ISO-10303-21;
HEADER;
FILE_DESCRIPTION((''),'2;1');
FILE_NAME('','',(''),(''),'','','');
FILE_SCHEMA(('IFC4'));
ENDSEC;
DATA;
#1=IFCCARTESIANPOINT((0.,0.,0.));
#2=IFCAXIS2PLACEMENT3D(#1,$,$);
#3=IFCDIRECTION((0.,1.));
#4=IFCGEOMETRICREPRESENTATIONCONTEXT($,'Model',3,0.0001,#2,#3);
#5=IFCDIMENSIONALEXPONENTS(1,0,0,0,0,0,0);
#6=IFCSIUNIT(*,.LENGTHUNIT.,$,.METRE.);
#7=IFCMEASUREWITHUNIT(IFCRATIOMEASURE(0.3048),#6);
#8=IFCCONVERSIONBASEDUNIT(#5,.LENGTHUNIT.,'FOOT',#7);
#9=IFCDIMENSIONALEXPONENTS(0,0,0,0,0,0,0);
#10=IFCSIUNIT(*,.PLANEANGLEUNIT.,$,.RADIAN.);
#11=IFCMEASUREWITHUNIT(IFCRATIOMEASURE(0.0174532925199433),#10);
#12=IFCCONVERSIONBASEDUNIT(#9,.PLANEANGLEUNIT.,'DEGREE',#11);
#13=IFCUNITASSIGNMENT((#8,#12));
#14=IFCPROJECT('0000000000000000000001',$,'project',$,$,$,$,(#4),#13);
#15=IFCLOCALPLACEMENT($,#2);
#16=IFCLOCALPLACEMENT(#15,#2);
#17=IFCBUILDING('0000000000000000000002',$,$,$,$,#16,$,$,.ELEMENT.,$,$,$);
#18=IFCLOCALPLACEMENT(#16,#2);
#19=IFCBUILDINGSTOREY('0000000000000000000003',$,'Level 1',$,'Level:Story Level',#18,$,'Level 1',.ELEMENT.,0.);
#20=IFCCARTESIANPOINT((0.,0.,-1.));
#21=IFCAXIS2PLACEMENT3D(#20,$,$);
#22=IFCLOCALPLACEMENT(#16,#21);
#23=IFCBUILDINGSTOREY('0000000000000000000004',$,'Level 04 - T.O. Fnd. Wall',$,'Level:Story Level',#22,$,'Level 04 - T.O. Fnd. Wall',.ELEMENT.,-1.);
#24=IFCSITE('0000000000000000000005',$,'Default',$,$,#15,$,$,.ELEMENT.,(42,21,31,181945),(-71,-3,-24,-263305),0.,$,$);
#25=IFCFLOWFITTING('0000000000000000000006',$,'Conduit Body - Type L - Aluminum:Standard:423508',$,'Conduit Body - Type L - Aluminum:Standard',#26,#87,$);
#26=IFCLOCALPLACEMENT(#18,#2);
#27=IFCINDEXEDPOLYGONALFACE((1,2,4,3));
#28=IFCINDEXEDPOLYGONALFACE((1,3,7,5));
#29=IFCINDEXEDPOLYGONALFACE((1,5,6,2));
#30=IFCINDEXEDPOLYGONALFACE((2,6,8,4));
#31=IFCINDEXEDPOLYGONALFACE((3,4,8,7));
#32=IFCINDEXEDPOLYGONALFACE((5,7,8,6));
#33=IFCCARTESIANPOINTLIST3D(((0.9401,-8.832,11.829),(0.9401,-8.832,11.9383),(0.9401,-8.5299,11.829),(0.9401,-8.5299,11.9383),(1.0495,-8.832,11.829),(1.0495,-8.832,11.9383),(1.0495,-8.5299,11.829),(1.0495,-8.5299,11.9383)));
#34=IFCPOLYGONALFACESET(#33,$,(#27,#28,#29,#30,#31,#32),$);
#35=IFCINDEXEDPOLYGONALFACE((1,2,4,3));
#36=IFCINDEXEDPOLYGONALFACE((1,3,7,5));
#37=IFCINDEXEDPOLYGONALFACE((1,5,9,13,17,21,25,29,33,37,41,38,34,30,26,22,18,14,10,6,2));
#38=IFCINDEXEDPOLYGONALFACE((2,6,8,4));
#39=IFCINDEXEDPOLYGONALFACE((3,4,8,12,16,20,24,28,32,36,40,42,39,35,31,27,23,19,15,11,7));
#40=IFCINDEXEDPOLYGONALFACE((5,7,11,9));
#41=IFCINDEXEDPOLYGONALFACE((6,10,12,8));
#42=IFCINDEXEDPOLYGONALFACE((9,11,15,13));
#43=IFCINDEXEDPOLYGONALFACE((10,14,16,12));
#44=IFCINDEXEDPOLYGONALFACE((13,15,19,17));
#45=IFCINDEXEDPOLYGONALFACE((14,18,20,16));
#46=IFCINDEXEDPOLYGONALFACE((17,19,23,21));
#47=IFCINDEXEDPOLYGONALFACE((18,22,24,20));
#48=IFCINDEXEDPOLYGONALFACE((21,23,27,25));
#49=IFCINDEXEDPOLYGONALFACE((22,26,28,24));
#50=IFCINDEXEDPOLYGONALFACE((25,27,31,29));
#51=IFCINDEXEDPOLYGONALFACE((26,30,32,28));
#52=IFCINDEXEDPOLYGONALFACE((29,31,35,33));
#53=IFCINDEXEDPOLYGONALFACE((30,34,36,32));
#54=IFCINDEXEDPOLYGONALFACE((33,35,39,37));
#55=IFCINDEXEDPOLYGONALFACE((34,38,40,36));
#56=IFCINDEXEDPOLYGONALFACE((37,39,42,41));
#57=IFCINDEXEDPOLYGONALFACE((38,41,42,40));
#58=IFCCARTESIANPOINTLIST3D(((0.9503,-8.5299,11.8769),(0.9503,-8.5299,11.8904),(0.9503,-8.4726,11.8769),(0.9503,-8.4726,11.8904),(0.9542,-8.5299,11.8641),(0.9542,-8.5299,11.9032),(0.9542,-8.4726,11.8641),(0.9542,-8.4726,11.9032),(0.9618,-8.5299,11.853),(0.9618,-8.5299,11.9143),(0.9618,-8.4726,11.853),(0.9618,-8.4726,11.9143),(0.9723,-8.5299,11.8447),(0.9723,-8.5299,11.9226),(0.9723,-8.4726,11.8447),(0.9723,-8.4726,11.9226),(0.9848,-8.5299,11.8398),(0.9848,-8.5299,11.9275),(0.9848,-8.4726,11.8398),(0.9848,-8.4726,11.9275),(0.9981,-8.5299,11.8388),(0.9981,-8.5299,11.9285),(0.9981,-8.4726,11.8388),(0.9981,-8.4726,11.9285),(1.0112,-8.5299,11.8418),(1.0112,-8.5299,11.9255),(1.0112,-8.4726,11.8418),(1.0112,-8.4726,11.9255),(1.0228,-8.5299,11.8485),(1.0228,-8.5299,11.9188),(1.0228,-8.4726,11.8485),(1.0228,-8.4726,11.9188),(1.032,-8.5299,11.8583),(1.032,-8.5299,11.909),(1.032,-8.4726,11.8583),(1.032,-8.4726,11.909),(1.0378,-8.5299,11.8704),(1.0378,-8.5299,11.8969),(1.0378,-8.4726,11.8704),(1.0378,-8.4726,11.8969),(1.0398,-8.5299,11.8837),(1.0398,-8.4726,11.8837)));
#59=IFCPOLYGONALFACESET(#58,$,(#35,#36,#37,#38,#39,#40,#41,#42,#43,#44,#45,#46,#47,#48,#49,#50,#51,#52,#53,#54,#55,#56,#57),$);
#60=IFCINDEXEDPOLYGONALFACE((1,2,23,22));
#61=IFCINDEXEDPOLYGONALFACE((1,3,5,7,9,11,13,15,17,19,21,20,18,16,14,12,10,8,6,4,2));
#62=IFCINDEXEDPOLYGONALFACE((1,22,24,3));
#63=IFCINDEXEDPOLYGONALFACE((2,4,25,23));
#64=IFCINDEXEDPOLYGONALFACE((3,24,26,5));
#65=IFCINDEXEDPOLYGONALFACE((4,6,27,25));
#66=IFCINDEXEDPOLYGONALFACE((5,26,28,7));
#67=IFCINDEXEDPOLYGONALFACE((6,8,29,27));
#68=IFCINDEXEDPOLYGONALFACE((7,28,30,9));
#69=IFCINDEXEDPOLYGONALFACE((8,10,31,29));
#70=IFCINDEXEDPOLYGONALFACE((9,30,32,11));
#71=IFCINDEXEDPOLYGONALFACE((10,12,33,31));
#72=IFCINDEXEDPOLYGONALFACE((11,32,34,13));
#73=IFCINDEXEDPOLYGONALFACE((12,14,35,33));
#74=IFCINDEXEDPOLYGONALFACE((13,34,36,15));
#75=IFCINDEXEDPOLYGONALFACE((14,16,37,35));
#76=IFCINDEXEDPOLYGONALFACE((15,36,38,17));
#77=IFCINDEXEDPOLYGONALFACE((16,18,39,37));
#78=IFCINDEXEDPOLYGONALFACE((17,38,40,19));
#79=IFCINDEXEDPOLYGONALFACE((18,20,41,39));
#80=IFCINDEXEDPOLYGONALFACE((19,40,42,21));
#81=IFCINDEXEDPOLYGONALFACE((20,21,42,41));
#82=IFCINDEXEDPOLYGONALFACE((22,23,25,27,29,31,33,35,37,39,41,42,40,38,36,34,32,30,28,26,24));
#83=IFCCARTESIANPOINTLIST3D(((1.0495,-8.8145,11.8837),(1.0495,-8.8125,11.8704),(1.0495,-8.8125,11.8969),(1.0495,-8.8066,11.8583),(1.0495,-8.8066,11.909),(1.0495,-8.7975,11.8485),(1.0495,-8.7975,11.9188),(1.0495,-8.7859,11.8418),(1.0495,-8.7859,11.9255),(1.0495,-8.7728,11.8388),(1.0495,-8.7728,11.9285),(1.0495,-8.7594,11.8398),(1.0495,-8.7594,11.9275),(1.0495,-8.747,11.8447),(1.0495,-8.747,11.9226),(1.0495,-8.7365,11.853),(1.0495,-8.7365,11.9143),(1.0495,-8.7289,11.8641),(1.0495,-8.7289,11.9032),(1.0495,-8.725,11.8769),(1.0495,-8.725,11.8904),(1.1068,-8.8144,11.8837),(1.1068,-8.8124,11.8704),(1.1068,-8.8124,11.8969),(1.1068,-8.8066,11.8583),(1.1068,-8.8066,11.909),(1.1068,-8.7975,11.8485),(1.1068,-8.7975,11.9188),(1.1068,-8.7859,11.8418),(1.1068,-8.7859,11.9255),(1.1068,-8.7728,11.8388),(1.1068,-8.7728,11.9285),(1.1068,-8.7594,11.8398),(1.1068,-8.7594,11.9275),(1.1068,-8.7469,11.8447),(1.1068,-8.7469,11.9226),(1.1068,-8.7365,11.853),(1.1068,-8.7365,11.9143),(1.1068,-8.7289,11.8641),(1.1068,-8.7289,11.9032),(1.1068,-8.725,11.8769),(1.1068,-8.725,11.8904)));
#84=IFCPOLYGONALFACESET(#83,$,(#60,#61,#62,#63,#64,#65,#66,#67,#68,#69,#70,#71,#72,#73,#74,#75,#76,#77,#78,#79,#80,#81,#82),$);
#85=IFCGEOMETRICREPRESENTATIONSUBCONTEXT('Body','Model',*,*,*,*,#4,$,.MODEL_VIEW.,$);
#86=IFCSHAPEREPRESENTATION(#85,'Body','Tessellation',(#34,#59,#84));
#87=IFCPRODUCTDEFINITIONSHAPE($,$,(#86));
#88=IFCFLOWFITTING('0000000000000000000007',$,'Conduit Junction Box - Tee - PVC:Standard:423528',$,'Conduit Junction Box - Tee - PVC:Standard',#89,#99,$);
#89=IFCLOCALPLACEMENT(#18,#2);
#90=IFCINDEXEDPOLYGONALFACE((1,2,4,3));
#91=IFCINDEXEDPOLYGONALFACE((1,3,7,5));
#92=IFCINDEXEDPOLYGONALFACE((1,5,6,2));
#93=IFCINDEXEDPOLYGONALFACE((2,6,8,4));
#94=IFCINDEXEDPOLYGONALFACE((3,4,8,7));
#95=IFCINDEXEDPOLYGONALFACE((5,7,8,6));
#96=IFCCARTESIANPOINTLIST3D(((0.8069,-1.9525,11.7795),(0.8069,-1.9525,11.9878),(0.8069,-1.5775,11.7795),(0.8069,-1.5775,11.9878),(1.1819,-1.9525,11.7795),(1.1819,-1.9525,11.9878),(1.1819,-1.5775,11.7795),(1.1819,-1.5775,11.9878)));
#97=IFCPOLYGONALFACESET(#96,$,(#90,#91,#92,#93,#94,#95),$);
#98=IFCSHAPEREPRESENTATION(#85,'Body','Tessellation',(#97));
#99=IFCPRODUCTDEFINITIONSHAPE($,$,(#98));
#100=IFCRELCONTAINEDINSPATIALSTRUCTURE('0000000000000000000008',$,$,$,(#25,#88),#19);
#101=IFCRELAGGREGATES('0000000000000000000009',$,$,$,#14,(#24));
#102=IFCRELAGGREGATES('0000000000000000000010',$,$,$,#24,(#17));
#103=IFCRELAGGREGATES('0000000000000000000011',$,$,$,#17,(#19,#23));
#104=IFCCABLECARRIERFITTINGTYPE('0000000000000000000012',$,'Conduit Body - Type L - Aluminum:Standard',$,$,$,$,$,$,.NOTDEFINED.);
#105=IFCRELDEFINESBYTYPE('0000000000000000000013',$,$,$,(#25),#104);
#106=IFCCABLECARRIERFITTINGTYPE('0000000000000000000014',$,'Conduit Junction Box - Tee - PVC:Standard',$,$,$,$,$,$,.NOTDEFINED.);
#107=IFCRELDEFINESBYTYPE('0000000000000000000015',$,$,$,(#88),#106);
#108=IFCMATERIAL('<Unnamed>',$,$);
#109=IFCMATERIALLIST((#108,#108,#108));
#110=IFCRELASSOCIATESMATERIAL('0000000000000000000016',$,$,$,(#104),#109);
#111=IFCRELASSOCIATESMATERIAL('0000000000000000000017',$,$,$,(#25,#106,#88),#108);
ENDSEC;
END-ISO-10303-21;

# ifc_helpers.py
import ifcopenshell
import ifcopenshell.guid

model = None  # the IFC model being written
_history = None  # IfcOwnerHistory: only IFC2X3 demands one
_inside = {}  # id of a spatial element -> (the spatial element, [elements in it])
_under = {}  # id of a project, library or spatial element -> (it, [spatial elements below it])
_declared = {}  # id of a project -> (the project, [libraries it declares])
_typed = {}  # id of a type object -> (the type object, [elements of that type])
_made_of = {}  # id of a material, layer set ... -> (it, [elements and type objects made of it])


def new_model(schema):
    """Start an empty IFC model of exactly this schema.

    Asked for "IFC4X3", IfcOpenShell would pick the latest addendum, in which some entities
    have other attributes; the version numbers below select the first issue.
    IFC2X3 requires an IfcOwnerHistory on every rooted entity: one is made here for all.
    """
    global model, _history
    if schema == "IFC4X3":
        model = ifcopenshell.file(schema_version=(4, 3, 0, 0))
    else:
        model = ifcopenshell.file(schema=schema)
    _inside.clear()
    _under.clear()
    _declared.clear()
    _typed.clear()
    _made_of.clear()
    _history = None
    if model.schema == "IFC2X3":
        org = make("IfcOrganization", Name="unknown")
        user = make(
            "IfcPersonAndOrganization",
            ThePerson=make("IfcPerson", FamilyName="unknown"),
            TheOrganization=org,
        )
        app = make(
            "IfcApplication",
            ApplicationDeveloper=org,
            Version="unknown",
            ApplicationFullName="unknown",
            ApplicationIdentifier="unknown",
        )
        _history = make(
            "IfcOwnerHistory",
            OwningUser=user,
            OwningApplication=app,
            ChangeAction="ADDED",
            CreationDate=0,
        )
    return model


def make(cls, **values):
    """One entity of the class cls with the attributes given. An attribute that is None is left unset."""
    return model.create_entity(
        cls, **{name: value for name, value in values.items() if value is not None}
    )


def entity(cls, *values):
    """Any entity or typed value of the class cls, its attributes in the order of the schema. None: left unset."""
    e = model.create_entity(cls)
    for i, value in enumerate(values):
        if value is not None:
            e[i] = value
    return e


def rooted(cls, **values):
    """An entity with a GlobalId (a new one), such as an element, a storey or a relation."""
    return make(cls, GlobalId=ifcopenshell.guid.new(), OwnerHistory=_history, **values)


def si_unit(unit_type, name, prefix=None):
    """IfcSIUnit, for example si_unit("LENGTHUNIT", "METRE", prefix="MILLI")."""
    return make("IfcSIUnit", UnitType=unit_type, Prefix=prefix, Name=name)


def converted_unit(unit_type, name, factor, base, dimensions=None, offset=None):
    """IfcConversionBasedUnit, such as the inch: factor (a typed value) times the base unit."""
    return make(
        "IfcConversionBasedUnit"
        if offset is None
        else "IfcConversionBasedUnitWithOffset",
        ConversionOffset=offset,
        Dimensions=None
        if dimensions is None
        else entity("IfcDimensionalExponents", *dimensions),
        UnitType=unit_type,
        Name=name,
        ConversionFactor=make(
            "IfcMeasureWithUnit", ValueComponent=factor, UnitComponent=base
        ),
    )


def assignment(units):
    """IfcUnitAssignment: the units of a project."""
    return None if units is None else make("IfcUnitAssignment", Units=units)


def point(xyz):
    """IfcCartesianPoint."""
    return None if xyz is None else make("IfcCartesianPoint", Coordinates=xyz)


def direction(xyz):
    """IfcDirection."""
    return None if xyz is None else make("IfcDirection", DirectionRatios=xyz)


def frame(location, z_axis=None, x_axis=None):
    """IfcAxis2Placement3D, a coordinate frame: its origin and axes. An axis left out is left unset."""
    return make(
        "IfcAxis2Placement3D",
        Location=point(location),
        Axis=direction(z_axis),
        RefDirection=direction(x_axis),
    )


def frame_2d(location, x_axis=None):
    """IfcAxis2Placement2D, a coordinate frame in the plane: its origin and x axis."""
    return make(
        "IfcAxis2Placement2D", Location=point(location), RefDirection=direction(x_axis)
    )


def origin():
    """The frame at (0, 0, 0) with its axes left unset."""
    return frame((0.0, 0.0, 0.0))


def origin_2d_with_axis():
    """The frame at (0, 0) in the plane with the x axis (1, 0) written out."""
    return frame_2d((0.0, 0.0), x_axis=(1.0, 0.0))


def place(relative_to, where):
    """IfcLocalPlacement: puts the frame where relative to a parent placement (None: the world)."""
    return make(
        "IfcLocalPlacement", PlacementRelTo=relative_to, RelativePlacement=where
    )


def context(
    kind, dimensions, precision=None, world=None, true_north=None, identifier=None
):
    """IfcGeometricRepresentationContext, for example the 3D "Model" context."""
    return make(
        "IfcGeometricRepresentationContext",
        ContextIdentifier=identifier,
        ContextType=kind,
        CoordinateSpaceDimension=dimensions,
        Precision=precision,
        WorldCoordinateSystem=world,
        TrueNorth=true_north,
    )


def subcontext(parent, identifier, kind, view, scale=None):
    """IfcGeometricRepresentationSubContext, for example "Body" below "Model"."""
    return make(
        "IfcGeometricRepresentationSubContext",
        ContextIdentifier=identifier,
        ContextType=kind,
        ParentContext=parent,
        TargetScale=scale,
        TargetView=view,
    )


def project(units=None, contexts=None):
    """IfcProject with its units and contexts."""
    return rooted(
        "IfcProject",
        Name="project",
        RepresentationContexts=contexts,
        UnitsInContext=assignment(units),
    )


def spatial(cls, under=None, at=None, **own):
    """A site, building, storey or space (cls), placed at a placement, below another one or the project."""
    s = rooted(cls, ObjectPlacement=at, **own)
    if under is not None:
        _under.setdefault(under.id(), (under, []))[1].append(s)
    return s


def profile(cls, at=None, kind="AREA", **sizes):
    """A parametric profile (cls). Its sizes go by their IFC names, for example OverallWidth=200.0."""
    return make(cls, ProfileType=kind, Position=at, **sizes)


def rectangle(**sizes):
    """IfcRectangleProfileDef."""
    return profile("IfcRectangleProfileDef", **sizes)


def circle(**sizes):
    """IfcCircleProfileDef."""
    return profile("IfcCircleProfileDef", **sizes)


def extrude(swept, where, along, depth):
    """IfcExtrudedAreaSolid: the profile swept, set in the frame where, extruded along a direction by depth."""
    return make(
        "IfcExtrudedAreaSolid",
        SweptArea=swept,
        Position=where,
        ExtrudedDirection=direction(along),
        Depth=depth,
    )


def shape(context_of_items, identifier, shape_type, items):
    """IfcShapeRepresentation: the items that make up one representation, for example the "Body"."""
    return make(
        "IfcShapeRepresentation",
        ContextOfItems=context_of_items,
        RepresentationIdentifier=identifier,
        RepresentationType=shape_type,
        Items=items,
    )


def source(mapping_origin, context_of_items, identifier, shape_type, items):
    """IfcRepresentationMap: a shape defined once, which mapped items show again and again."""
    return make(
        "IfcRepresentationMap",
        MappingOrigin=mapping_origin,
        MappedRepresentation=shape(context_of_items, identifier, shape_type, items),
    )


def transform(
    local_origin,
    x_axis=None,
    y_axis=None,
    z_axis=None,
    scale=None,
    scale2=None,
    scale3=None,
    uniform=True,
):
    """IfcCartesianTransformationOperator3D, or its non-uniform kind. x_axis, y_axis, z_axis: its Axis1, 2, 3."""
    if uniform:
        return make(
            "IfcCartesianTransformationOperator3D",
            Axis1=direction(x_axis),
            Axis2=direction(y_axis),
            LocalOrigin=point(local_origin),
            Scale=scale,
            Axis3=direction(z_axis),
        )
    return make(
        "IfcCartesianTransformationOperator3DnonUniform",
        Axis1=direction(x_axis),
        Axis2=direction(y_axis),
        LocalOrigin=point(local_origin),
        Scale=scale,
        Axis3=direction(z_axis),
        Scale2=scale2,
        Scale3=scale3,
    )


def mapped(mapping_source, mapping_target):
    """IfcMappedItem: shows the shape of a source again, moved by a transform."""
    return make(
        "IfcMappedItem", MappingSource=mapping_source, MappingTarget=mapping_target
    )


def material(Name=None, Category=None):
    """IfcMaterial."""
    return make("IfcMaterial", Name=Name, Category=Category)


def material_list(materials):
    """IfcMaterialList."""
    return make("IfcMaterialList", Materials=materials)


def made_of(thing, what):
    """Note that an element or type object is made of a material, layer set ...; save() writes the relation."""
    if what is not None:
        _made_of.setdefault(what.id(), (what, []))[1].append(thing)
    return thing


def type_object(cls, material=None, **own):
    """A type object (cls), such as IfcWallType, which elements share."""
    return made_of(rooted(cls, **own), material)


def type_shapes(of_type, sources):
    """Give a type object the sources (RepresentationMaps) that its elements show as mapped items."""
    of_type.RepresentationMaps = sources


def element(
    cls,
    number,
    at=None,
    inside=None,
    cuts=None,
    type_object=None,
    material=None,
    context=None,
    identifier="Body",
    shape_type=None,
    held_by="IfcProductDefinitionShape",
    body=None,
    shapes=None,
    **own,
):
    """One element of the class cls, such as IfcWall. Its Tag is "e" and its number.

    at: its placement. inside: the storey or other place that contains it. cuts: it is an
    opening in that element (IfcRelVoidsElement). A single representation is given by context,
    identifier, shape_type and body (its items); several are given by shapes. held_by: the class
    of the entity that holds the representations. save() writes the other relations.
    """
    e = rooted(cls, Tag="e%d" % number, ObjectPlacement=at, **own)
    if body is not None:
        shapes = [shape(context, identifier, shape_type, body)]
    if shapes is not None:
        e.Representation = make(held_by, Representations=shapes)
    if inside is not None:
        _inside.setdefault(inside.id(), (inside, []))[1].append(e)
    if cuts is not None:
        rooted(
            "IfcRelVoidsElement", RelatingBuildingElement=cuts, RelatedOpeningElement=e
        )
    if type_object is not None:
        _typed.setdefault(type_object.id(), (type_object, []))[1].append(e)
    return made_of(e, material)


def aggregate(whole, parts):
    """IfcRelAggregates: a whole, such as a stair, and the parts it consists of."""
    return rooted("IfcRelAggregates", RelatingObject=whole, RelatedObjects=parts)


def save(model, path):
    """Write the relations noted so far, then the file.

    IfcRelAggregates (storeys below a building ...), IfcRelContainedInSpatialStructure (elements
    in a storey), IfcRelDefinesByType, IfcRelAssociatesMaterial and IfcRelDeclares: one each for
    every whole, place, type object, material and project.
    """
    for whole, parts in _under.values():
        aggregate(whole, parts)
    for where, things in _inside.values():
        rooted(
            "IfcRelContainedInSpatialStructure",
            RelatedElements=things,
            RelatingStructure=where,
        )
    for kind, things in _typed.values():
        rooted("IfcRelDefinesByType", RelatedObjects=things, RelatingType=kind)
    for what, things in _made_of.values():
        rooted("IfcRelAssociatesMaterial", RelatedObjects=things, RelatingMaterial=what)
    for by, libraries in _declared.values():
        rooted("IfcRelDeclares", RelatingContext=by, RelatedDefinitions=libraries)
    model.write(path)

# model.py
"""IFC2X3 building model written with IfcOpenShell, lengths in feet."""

from ifc_helpers import new_model, entity, si_unit, converted_unit, direction, frame, frame_2d, origin, origin_2d_with_axis, place, context, subcontext, project, spatial, rectangle, circle, extrude, source, transform, mapped, material, material_list, type_object, type_shapes, element, save


model = new_model("IFC2X3")

# Units and contexts
model_context = context("Model", 3, precision=0.0001, world=origin(), true_north=direction((0.0, 1.0)))
body_context = subcontext(model_context, "Body", "Model", "MODEL_VIEW")
ifc_project = project(units=[converted_unit("LENGTHUNIT", "FOOT", entity("IfcRatioMeasure", 0.3048), si_unit("LENGTHUNIT", "METRE"), dimensions=[1, 0, 0, 0, 0, 0, 0]), converted_unit("PLANEANGLEUNIT", "DEGREE", entity("IfcRatioMeasure", 0.0174532925199433), si_unit("PLANEANGLEUNIT", "RADIAN"), dimensions=[0, 0, 0, 0, 0, 0, 0])], contexts=[model_context])

# Site, building, storey
site_placement = place(None, origin())
site = spatial("IfcSite", under=ifc_project, at=site_placement, Name="Default", CompositionType="ELEMENT", RefLatitude=(42, 21, 31, 181945), RefLongitude=(-71, -3, -24, -263305), RefElevation=0.0)
building_placement = place(site_placement, origin())
building = spatial("IfcBuilding", under=site, at=building_placement, CompositionType="ELEMENT")
storey_1_placement = place(building_placement, origin())
storey_1 = spatial("IfcBuildingStorey", under=building, at=storey_1_placement, Name="Level 1", ObjectType="Level:Story Level", LongName="Level 1", CompositionType="ELEMENT", Elevation=0.0)

# Shared definitions
storey_2_placement = place(building_placement, frame((0.0, 0.0, -1.0)))
storey_2 = spatial("IfcBuildingStorey", under=building, at=storey_2_placement, Name="Level 04 - T.O. Fnd. Wall", ObjectType="Level:Story Level", LongName="Level 04 - T.O. Fnd. Wall", CompositionType="ELEMENT", Elevation=-1.0)

# Shared definitions
ifc_material_1 = material(Name="<Unnamed>")

# Flow fittings
ifc_material_list_1 = material_list([ifc_material_1, ifc_material_1, ifc_material_1])
cable_carrier_fitting_type_1 = type_object("IfcCableCarrierFittingType", Name="Conduit Body - Type L - Aluminum:Standard", PredefinedType="NOTDEFINED", material=ifc_material_list_1)
shared_shape_1 = source(origin(), body_context, "Body", "SweptSolid", [
    extrude(rectangle(XDim=0.3021, YDim=0.1094, at=origin_2d_with_axis()), frame((-0.0885, 0.0, -0.0547), z_axis=(0.0, 0.0, 1.0), x_axis=(-1.0, 0.0, 0.0)), (0.0, 0.0, 1.0), 0.1094),
    extrude(circle(Radius=0.045, at=frame_2d((0.0, 0.0), x_axis=(1.0, 0.0))), frame((-0.2969, 0.0, 0.0), z_axis=(1.0, 0.0, 0.0), x_axis=(0.0, 1.0, 0.0)), (0.0, 0.0, 1.0), 0.0573),
    extrude(circle(Radius=0.045, at=frame_2d((0.0, 0.0), x_axis=(1.0, 0.0))), frame((0.0, 0.0547, 0.0), z_axis=(0.0, 1.0, 0.0), x_axis=(1.0, 0.0, 0.0)), (0.0, 0.0, 1.0), 0.0573),
])
type_shapes(cable_carrier_fitting_type_1, [shared_shape_1])
flow_fitting_1_placement = place(storey_1_placement, frame((0.9948, -8.7695, 11.8837), z_axis=(0.0, 0.0, 1.0), x_axis=(0.000051, -1.0, 0.0)))
element("IfcFlowFitting", 1, at=flow_fitting_1_placement, inside=storey_1, type_object=cable_carrier_fitting_type_1, material=ifc_material_1, Name="Conduit Body - Type L - Aluminum:Standard:423508", ObjectType="Conduit Body - Type L - Aluminum:Standard", context=body_context, shape_type="MappedRepresentation", body=[
    mapped(shared_shape_1, transform((0.0, 0.0, 0.0), scale=1.0)),
])
cable_carrier_fitting_type_2 = type_object("IfcCableCarrierFittingType", Name="Conduit Junction Box - Tee - PVC:Standard", PredefinedType="NOTDEFINED", material=ifc_material_1)
shared_shape_2 = source(origin(), body_context, "Body", "SweptSolid", [
    extrude(rectangle(XDim=0.375, YDim=0.375, at=frame_2d((0.0, 0.0), x_axis=(1.0, 0.0))), frame((0.0, 0.0, -0.1042), z_axis=(0.0, 0.0, 1.0), x_axis=(0.0, 1.0, 0.0)), (0.0, 0.0, 1.0), 0.2083),
])
type_shapes(cable_carrier_fitting_type_2, [shared_shape_2])
flow_fitting_2_placement = place(storey_1_placement, frame((0.9944, -1.765, 11.8837), z_axis=(0.0, 0.0, 1.0), x_axis=(0.000051, -1.0, 0.0)))
element("IfcFlowFitting", 2, at=flow_fitting_2_placement, inside=storey_1, type_object=cable_carrier_fitting_type_2, material=ifc_material_1, Name="Conduit Junction Box - Tee - PVC:Standard:423528", ObjectType="Conduit Junction Box - Tee - PVC:Standard", context=body_context, shape_type="MappedRepresentation", body=[
    mapped(shared_shape_2, transform((0.0, 0.0, 0.0), scale=1.0)),
])

save(model, "model.ifc")
